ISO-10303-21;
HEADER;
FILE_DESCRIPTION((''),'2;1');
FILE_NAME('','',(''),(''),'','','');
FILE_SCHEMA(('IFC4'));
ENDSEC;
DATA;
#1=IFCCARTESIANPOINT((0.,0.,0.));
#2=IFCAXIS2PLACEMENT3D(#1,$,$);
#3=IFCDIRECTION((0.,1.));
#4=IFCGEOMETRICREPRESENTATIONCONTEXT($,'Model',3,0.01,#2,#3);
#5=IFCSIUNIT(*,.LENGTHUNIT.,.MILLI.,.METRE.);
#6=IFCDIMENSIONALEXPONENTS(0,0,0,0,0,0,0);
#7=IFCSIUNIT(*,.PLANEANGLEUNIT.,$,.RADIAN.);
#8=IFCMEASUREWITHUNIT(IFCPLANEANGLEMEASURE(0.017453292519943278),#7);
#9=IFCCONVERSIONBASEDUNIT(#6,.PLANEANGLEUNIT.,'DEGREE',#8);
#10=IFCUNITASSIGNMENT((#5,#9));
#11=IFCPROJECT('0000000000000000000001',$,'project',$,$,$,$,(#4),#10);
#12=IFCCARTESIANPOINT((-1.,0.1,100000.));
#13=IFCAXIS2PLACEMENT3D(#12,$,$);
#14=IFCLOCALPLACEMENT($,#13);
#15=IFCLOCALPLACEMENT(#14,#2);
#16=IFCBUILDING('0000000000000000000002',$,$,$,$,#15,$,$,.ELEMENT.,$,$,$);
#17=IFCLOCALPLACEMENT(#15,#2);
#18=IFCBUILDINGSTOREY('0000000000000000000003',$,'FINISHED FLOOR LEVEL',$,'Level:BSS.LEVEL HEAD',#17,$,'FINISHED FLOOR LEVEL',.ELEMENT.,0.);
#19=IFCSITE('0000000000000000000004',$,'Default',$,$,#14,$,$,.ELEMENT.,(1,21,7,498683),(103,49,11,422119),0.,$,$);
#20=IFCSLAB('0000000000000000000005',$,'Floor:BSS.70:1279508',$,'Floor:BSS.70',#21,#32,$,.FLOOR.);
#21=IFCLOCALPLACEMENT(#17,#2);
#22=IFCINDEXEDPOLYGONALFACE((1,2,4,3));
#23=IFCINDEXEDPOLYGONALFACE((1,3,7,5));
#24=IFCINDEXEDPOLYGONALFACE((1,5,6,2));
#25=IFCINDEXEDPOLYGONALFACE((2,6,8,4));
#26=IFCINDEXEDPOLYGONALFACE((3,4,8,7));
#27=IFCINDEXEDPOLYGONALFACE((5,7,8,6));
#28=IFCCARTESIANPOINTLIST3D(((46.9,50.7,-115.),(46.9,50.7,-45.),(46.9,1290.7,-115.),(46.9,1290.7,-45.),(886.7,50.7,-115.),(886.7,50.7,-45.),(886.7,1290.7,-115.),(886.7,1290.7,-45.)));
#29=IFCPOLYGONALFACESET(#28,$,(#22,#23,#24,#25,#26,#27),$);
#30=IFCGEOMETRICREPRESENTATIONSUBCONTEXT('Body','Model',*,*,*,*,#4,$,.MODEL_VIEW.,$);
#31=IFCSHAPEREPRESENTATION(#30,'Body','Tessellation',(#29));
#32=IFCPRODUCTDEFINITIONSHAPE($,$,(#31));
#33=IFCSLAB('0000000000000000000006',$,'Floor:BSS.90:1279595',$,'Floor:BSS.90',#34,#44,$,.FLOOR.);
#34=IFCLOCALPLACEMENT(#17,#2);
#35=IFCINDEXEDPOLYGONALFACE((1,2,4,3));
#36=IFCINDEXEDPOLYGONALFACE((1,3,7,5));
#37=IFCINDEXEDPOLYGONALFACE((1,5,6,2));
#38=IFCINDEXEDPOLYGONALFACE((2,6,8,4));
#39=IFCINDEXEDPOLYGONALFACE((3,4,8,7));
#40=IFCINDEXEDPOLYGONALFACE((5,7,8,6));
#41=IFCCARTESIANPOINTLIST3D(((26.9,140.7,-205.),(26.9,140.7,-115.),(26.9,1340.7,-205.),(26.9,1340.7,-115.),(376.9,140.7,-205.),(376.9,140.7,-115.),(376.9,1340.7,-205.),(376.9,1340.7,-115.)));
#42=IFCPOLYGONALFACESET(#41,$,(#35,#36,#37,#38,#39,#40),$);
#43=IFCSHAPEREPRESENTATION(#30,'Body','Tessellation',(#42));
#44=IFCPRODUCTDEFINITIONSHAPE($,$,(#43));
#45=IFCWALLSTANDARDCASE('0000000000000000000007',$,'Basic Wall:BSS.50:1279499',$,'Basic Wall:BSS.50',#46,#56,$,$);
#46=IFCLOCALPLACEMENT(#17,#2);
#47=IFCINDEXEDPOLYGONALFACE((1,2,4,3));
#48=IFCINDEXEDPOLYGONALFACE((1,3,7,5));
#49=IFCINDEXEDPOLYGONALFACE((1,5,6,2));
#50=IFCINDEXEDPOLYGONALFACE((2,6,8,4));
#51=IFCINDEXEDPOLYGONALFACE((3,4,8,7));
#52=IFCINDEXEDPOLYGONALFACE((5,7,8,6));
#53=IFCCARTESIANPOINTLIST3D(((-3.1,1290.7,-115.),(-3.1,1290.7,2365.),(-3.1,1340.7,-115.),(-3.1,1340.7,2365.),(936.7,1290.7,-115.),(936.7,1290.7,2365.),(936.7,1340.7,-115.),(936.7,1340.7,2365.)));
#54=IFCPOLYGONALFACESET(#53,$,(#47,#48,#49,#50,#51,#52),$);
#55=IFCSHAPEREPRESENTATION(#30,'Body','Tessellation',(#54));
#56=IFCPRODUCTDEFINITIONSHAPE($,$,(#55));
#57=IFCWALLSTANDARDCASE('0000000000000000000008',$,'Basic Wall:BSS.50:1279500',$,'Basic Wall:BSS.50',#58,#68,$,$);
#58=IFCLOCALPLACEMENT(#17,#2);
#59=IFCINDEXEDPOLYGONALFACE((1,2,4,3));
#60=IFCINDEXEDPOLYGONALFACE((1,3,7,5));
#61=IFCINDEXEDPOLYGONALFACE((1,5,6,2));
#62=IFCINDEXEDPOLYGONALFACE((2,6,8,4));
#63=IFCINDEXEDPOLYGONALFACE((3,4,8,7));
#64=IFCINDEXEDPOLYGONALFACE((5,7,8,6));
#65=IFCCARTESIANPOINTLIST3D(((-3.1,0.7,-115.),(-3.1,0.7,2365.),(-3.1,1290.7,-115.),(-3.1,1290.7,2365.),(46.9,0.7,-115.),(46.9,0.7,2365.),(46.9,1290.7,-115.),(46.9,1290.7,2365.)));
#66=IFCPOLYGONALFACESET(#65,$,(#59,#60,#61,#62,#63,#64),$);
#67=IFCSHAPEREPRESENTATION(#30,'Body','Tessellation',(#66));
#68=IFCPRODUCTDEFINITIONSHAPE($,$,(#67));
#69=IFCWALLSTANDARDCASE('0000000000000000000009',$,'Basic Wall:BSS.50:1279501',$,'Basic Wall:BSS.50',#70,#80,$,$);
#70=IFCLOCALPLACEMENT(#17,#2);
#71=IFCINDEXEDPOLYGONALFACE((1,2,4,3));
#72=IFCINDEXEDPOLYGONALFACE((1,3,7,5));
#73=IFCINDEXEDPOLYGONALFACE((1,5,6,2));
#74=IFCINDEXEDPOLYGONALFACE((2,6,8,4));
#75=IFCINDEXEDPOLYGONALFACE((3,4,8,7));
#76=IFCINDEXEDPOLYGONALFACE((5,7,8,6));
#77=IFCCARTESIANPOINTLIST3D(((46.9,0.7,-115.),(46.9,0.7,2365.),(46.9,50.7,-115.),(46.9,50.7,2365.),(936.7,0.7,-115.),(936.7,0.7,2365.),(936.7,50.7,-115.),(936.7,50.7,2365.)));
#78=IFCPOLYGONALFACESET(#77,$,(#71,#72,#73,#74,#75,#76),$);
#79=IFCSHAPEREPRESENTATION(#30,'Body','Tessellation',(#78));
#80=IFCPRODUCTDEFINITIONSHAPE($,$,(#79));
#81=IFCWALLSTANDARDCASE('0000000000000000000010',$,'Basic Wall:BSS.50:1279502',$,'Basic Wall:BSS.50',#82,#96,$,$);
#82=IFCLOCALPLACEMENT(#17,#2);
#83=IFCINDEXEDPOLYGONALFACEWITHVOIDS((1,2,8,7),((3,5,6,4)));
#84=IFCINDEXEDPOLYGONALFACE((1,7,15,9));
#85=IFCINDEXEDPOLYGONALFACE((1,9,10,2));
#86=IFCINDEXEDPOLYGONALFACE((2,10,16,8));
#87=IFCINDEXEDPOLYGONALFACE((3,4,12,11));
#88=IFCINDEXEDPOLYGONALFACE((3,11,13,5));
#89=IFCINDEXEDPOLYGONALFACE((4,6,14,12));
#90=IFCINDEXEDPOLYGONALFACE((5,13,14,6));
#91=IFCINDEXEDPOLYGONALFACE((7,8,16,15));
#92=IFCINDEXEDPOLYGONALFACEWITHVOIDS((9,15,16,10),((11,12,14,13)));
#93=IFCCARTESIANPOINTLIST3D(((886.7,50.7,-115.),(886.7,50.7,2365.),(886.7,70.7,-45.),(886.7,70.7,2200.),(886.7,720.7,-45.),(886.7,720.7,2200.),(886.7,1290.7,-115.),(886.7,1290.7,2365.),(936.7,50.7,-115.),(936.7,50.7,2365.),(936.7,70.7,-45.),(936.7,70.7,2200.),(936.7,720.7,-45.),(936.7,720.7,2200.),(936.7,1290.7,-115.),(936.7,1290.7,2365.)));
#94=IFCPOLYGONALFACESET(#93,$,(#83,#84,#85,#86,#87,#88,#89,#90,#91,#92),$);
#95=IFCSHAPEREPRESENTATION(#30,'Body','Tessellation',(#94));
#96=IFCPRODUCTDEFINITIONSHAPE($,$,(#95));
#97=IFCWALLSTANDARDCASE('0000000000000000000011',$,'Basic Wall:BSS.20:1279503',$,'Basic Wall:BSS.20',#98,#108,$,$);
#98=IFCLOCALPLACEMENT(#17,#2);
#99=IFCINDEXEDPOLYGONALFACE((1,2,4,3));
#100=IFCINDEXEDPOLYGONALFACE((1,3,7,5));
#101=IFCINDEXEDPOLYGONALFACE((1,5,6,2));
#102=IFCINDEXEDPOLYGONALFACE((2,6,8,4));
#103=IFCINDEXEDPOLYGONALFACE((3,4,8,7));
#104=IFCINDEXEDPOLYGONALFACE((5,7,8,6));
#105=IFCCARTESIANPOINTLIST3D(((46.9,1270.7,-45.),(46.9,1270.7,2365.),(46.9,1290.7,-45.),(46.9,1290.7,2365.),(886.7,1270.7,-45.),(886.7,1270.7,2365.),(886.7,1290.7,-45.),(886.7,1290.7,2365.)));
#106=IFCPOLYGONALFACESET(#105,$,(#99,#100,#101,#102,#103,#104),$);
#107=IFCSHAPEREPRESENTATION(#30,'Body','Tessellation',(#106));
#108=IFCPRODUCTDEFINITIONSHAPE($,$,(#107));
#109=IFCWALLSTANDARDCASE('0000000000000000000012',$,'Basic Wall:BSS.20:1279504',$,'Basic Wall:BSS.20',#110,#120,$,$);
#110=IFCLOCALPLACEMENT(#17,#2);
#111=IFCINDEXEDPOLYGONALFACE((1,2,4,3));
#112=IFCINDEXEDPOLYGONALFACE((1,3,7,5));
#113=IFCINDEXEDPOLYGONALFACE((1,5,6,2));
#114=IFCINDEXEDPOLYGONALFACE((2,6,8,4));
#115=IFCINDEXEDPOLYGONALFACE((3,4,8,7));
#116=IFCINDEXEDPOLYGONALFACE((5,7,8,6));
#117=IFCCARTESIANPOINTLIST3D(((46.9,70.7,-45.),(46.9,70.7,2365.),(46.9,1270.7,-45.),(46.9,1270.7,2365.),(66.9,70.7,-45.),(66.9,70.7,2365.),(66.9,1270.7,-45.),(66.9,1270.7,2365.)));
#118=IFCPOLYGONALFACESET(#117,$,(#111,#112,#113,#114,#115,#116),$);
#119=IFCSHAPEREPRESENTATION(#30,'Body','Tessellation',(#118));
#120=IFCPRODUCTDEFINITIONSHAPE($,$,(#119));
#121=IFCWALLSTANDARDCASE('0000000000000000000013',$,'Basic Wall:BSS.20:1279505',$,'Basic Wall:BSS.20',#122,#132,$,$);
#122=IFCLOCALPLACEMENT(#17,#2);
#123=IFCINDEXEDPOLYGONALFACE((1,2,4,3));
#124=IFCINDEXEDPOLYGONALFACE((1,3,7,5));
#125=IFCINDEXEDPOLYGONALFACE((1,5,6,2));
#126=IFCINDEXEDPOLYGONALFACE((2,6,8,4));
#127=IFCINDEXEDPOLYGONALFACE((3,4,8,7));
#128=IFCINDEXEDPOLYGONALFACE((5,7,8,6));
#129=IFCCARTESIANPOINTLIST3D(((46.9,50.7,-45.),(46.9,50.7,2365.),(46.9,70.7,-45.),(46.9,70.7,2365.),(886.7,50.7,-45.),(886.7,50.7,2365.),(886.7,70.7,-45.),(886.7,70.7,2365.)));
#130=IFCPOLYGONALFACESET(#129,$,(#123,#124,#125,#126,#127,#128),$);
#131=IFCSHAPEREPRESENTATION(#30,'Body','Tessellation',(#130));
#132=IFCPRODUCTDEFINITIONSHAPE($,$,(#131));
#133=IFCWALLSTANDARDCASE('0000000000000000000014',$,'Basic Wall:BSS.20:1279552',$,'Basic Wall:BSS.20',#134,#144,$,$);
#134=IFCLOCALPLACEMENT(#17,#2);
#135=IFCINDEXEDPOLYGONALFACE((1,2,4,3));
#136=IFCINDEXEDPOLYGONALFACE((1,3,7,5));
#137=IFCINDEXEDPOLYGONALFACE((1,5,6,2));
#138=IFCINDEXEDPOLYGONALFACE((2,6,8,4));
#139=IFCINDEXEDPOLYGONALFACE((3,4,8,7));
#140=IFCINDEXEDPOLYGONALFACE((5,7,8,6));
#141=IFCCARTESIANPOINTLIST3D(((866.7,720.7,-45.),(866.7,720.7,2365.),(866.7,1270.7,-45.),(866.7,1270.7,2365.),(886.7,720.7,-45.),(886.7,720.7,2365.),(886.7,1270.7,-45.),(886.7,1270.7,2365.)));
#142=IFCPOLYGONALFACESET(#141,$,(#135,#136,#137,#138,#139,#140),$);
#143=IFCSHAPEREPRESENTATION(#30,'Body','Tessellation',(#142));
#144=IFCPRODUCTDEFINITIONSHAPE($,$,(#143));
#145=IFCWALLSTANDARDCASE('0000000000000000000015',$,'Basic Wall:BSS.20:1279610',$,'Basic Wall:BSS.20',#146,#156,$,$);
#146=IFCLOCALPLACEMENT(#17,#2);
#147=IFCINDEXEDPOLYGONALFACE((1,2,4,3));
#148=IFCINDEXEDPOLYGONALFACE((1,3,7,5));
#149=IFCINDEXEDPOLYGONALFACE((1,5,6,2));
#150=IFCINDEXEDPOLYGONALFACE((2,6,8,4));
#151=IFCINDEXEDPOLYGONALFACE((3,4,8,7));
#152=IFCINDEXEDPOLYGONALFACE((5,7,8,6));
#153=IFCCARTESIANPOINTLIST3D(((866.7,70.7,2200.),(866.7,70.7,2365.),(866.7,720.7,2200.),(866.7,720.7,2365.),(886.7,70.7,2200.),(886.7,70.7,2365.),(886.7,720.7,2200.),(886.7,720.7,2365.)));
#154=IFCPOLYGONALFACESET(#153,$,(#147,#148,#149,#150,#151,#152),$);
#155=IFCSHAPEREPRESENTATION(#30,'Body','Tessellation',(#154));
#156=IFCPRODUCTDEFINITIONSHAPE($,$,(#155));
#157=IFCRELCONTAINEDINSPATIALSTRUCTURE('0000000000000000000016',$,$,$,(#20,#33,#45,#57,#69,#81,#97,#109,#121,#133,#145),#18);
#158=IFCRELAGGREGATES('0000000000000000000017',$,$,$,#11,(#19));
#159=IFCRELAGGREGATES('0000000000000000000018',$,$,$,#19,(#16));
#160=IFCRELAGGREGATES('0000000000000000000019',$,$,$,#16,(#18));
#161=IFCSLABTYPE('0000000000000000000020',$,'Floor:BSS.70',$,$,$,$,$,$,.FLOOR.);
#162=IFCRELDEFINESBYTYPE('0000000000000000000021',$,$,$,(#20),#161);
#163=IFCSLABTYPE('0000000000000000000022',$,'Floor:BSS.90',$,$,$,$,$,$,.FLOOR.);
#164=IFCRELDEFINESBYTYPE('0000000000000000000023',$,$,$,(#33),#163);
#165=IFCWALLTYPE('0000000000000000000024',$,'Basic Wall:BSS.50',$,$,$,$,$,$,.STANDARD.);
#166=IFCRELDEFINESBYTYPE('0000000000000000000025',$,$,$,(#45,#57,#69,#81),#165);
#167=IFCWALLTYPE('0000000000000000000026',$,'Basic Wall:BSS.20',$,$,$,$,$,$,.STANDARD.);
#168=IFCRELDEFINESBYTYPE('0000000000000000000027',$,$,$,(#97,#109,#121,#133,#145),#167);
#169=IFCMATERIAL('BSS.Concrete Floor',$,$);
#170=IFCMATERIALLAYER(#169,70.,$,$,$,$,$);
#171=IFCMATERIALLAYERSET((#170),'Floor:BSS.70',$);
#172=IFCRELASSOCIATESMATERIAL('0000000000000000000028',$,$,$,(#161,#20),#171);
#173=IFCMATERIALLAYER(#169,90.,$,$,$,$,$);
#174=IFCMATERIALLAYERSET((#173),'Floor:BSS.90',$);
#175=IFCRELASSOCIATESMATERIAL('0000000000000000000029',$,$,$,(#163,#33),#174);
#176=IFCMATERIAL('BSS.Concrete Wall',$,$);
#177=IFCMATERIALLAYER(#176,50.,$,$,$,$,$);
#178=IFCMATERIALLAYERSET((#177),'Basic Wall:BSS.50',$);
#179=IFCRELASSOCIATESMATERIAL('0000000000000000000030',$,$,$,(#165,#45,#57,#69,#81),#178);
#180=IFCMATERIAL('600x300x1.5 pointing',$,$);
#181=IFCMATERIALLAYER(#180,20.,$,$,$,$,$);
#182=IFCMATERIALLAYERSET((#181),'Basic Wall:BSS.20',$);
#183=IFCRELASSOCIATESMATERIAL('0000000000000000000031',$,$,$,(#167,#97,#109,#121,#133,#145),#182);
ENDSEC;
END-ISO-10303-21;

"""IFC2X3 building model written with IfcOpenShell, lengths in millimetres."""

from ifc_helpers import new_model, entity, si_unit, converted_unit, direction, frame, frame_2d, origin, place, context, subcontext, project, spatial, polyline, rectangle, extrude, clip, halfspace, bounded_halfspace, material, layer, layer_set, layer_usage, type_object, element, save


model = new_model("IFC2X3")

# Units and contexts
model_context = context("Model", 3, precision=0.01, world=origin(), true_north=direction((0.0, 1.0)))
body_context = subcontext(model_context, "Body", "Model", "MODEL_VIEW")
ifc_project = project(units=[si_unit("LENGTHUNIT", "METRE", prefix="MILLI"), converted_unit("PLANEANGLEUNIT", "DEGREE", entity("IfcPlaneAngleMeasure", 0.017453292519943278), si_unit("PLANEANGLEUNIT", "RADIAN"), dimensions=[0, 0, 0, 0, 0, 0, 0])], contexts=[model_context])

# Site, building, storey
site_placement = place(None, frame((-1.0, 0.1, 100000.0)))
site = spatial("IfcSite", under=ifc_project, at=site_placement, Name="Default", CompositionType="ELEMENT", RefLatitude=(1, 21, 7, 498683), RefLongitude=(103, 49, 11, 422119), RefElevation=0.0)
building_placement = place(site_placement, origin())
building = spatial("IfcBuilding", under=site, at=building_placement, CompositionType="ELEMENT")
storey_placement = place(building_placement, origin())
storey = spatial("IfcBuildingStorey", under=building, at=storey_placement, Name="FINISHED FLOOR LEVEL", ObjectType="Level:BSS.LEVEL HEAD", LongName="FINISHED FLOOR LEVEL", CompositionType="ELEMENT", Elevation=0.0)

# Slabs
ifc_material_1 = material(Name="BSS.Concrete Floor")
ifc_layer_1 = layer(ifc_material_1, 70.0)
ifc_layer_set_1 = layer_set([ifc_layer_1], Name="Floor:BSS.70")
ifc_layer_usage_1 = layer_usage(ifc_layer_set_1, "AXIS3", "POSITIVE", 0.0)
slab_type_1 = type_object("IfcSlabType", Name="Floor:BSS.70", PredefinedType="FLOOR", material=ifc_layer_set_1)
slab_1_placement = place(storey_placement, origin())
element("IfcSlab", 1, at=slab_1_placement, inside=storey, type_object=slab_type_1, material=ifc_layer_usage_1, Name="Floor:BSS.70:1279508", ObjectType="Floor:BSS.70", PredefinedType="FLOOR", context=body_context, shape_type="SweptSolid", body=[
    extrude(rectangle(XDim=1240.0, YDim=839.7, at=frame_2d((0.0, 0.0), x_axis=(1.0, 0.0))), frame((466.8, 670.7, -45.0), z_axis=(0.0, 0.0, -1.0), x_axis=(0.0, 1.0, 0.0)), (0.0, 0.0, 1.0), 70.0),
])
ifc_material_2 = material(Name="600x300x1.5 pointing")
ifc_layer_2 = layer(ifc_material_1, 90.0)
ifc_layer_set_2 = layer_set([ifc_layer_2], Name="Floor:BSS.90")
ifc_layer_usage_2 = layer_usage(ifc_layer_set_2, "AXIS3", "POSITIVE", 0.0)
slab_type_2 = type_object("IfcSlabType", Name="Floor:BSS.90", PredefinedType="FLOOR", material=ifc_layer_set_2)
slab_2_placement = place(storey_placement, origin())
element("IfcSlab", 2, at=slab_2_placement, inside=storey, type_object=slab_type_2, material=ifc_layer_usage_2, Name="Floor:BSS.90:1279595", ObjectType="Floor:BSS.90", PredefinedType="FLOOR", context=body_context, shape_type="SweptSolid", body=[
    extrude(rectangle(XDim=1200.0, YDim=350.0, at=frame_2d((0.0, 0.0), x_axis=(1.0, 0.0))), frame((201.9, 740.7, -115.0), z_axis=(0.0, 0.0, -1.0), x_axis=(0.0, 1.0, 0.0)), (0.0, 0.0, 1.0), 90.0),
])

# Walls
ifc_material_3 = material(Name="BSS.Concrete Wall")
ifc_layer_3 = layer(ifc_material_3, 50.0)
ifc_layer_set_3 = layer_set([ifc_layer_3], Name="Basic Wall:BSS.50")
ifc_layer_usage_3 = layer_usage(ifc_layer_set_3, "AXIS2", "POSITIVE", -25.0)
wall_type_1 = type_object("IfcWallType", Name="Basic Wall:BSS.50", PredefinedType="STANDARD", material=ifc_layer_set_3)
wall_1_placement = place(storey_placement, frame((936.7, 1315.7, -115.0), z_axis=(0.0, 0.0, 1.0), x_axis=(-1.0, 0.0, 0.0)))
element("IfcWallStandardCase", 3, at=wall_1_placement, inside=storey, type_object=wall_type_1, material=ifc_layer_usage_3, Name="Basic Wall:BSS.50:1279499", ObjectType="Basic Wall:BSS.50", context=body_context, shape_type="Clipping", body=[
    clip(extrude(rectangle(XDim=939.7, YDim=50.0, at=frame_2d((469.9, 0.0), x_axis=(-1.0, 0.0))), origin(), (0.0, 0.0, 1.0), 2480.0), bounded_halfspace(frame((0.0, -25.0, 2480.0), z_axis=(0.0, 0.0, -1.0), x_axis=(0.0, 1.0, 0.0)), True, frame((0.0, -25.0, 2480.0)), polyline([(0.0, 0.0), (939.7, 0.0), (939.7, 50.0), (889.7, 50.0), (50.0, 50.0), (0.0, 50.0), (0.0, 0.0)]))),
])
ifc_layer_usage_4 = layer_usage(ifc_layer_set_3, "AXIS2", "NEGATIVE", 25.0)
wall_2_placement = place(storey_placement, frame((21.9, 1290.7, -115.0), z_axis=(0.0, 0.0, 1.0), x_axis=(0.0, -1.0, 0.0)))
element("IfcWallStandardCase", 4, at=wall_2_placement, inside=storey, type_object=wall_type_1, material=ifc_layer_usage_4, Name="Basic Wall:BSS.50:1279500", ObjectType="Basic Wall:BSS.50", context=body_context, shape_type="Clipping", body=[
    clip(extrude(rectangle(XDim=1290.0, YDim=50.0, at=frame_2d((645.0, 0.0), x_axis=(-1.0, 0.0))), origin(), (0.0, 0.0, 1.0), 2480.0), bounded_halfspace(frame((0.0, -25.0, 2480.0), z_axis=(0.0, 0.0, -1.0), x_axis=(1.0, 0.0, 0.0)), True, frame((0.0, -25.0, 2480.0)), polyline([(0.0, 0.0), (1290.0, 0.0), (1290.0, 50.0), (1240.0, 50.0), (0.0, 50.0), (0.0, 0.0)]))),
])
ifc_layer_usage_5 = layer_usage(ifc_layer_set_3, "AXIS2", "NEGATIVE", 25.0)
wall_3_placement = place(storey_placement, frame((46.9, 25.7, -115.0)))
element("IfcWallStandardCase", 5, at=wall_3_placement, inside=storey, type_object=wall_type_1, material=ifc_layer_usage_5, Name="Basic Wall:BSS.50:1279501", ObjectType="Basic Wall:BSS.50", context=body_context, shape_type="Clipping", body=[
    clip(extrude(rectangle(XDim=889.7, YDim=50.0, at=frame_2d((444.9, 0.0), x_axis=(-1.0, 0.0))), origin(), (0.0, 0.0, 1.0), 2480.0), bounded_halfspace(frame((0.0, -25.0, 2480.0), z_axis=(0.0, 0.0, -1.0), x_axis=(0.0, -1.0, 0.0)), True, frame((0.0, -25.0, 2480.0)), polyline([(0.0, 0.0), (889.7, 0.0), (889.7, 50.0), (839.7, 50.0), (0.0, 50.0), (0.0, 0.0)]))),
])

# Wall, opening
ifc_layer_usage_6 = layer_usage(ifc_layer_set_3, "AXIS2", "POSITIVE", -25.0)
wall_4_placement = place(storey_placement, frame((911.7, 50.7, -115.0), z_axis=(0.0, 0.0, 1.0), x_axis=(0.0, 1.0, 0.0)))
wall_4 = element("IfcWallStandardCase", 6, at=wall_4_placement, inside=storey, type_object=wall_type_1, material=ifc_layer_usage_6, Name="Basic Wall:BSS.50:1279502", ObjectType="Basic Wall:BSS.50", context=body_context, shape_type="Clipping", body=[
    clip(extrude(rectangle(XDim=1240.0, YDim=50.0, at=frame_2d((620.0, 0.0), x_axis=(-1.0, 0.0))), origin(), (0.0, 0.0, 1.0), 2480.0), bounded_halfspace(frame((0.0, -25.0, 2480.0), z_axis=(0.0, 0.0, -1.0), x_axis=(-1.0, 0.0, 0.0)), True, frame((0.0, -25.0, 2480.0)), polyline([(0.0, 0.0), (1240.0, 0.0), (1240.0, 50.0), (1220.0, 50.0), (0.0, 50.0), (0.0, 0.0)]))),
])
opening_placement = place(wall_4_placement, frame((-50.7, 911.7, 115.0), z_axis=(0.0, 0.0, 1.0), x_axis=(0.0, -1.0, 0.0)))
element("IfcOpeningElement", 7, at=opening_placement, cuts=wall_4, ObjectType="Opening", context=body_context, shape_type="SweptSolid", body=[
    extrude(rectangle(XDim=2245.0, YDim=650.0, at=frame_2d((0.0, 0.0), x_axis=(0.0, 1.0))), frame((2410.7, 395.7, 1077.5), z_axis=(-1.0, 0.0, 0.0), x_axis=(0.0, 1.0, 0.0)), (0.0, 0.0, 1.0), 3048.0),
])

# Walls
ifc_layer_4 = layer(ifc_material_2, 20.0)
ifc_layer_set_4 = layer_set([ifc_layer_4], Name="Basic Wall:BSS.20")
ifc_layer_usage_7 = layer_usage(ifc_layer_set_4, "AXIS2", "POSITIVE", -10.0)
wall_type_2 = type_object("IfcWallType", Name="Basic Wall:BSS.20", PredefinedType="STANDARD", material=ifc_layer_set_4)
wall_5_placement = place(storey_placement, frame((886.7, 1280.7, -45.0), z_axis=(0.0, 0.0, 1.0), x_axis=(-1.0, 0.0, 0.0)))
element("IfcWallStandardCase", 8, at=wall_5_placement, inside=storey, type_object=wall_type_2, material=ifc_layer_usage_7, Name="Basic Wall:BSS.20:1279503", ObjectType="Basic Wall:BSS.20", context=body_context, shape_type="SweptSolid", body=[
    extrude(rectangle(XDim=839.7, YDim=20.0, at=frame_2d((419.9, 0.0), x_axis=(-1.0, 0.0))), origin(), (0.0, 0.0, 1.0), 2410.0),
])
ifc_layer_usage_8 = layer_usage(ifc_layer_set_4, "AXIS2", "NEGATIVE", 10.0)
wall_6_placement = place(storey_placement, frame((56.9, 70.7, -45.0), z_axis=(0.0, 0.0, 1.0), x_axis=(0.0, 1.0, 0.0)))
element("IfcWallStandardCase", 9, at=wall_6_placement, inside=storey, type_object=wall_type_2, material=ifc_layer_usage_8, Name="Basic Wall:BSS.20:1279504", ObjectType="Basic Wall:BSS.20", context=body_context, shape_type="SweptSolid", body=[
    extrude(rectangle(XDim=1200.0, YDim=20.0, at=frame_2d((600.0, 0.0), x_axis=(-1.0, 0.0))), origin(), (0.0, 0.0, 1.0), 2410.0),
])
ifc_layer_usage_9 = layer_usage(ifc_layer_set_4, "AXIS2", "POSITIVE", -10.0)
wall_7_placement = place(storey_placement, frame((46.9, 60.7, -45.0)))
element("IfcWallStandardCase", 10, at=wall_7_placement, inside=storey, type_object=wall_type_2, material=ifc_layer_usage_9, Name="Basic Wall:BSS.20:1279505", ObjectType="Basic Wall:BSS.20", context=body_context, shape_type="SweptSolid", body=[
    extrude(rectangle(XDim=839.7, YDim=20.0, at=frame_2d((419.9, 0.0), x_axis=(-1.0, 0.0))), origin(), (0.0, 0.0, 1.0), 2410.0),
])
ifc_layer_usage_10 = layer_usage(ifc_layer_set_4, "AXIS2", "POSITIVE", -10.0)
wall_8_placement = place(storey_placement, frame((876.7, 720.7, -45.0), z_axis=(0.0, 0.0, 1.0), x_axis=(0.0, 1.0, 0.0)))
element("IfcWallStandardCase", 11, at=wall_8_placement, inside=storey, type_object=wall_type_2, material=ifc_layer_usage_10, Name="Basic Wall:BSS.20:1279552", ObjectType="Basic Wall:BSS.20", context=body_context, shape_type="SweptSolid", body=[
    extrude(rectangle(XDim=550.0, YDim=20.0, at=frame_2d((275.0, 0.0), x_axis=(-1.0, 0.0))), origin(), (0.0, 0.0, 1.0), 2410.0),
])
ifc_layer_usage_11 = layer_usage(ifc_layer_set_4, "AXIS2", "POSITIVE", -10.0)
wall_9_placement = place(storey_placement, frame((876.7, 70.7, 2200.0), z_axis=(0.0, 0.0, 1.0), x_axis=(0.0, 1.0, 0.0)))
element("IfcWallStandardCase", 12, at=wall_9_placement, inside=storey, type_object=wall_type_2, material=ifc_layer_usage_11, Name="Basic Wall:BSS.20:1279610", ObjectType="Basic Wall:BSS.20", context=body_context, shape_type="Clipping", body=[
    clip(extrude(rectangle(XDim=650.0, YDim=20.0, at=frame_2d((325.0, 0.0), x_axis=(-1.0, 0.0))), origin(), (0.0, 0.0, 1.0), 165.0), halfspace(frame((650.0, -10.0, 0.0), z_axis=(0.0, 0.0, -1.0), x_axis=(0.0, 1.0, 0.0)), False)),
])

save(model, "model.ifc")
